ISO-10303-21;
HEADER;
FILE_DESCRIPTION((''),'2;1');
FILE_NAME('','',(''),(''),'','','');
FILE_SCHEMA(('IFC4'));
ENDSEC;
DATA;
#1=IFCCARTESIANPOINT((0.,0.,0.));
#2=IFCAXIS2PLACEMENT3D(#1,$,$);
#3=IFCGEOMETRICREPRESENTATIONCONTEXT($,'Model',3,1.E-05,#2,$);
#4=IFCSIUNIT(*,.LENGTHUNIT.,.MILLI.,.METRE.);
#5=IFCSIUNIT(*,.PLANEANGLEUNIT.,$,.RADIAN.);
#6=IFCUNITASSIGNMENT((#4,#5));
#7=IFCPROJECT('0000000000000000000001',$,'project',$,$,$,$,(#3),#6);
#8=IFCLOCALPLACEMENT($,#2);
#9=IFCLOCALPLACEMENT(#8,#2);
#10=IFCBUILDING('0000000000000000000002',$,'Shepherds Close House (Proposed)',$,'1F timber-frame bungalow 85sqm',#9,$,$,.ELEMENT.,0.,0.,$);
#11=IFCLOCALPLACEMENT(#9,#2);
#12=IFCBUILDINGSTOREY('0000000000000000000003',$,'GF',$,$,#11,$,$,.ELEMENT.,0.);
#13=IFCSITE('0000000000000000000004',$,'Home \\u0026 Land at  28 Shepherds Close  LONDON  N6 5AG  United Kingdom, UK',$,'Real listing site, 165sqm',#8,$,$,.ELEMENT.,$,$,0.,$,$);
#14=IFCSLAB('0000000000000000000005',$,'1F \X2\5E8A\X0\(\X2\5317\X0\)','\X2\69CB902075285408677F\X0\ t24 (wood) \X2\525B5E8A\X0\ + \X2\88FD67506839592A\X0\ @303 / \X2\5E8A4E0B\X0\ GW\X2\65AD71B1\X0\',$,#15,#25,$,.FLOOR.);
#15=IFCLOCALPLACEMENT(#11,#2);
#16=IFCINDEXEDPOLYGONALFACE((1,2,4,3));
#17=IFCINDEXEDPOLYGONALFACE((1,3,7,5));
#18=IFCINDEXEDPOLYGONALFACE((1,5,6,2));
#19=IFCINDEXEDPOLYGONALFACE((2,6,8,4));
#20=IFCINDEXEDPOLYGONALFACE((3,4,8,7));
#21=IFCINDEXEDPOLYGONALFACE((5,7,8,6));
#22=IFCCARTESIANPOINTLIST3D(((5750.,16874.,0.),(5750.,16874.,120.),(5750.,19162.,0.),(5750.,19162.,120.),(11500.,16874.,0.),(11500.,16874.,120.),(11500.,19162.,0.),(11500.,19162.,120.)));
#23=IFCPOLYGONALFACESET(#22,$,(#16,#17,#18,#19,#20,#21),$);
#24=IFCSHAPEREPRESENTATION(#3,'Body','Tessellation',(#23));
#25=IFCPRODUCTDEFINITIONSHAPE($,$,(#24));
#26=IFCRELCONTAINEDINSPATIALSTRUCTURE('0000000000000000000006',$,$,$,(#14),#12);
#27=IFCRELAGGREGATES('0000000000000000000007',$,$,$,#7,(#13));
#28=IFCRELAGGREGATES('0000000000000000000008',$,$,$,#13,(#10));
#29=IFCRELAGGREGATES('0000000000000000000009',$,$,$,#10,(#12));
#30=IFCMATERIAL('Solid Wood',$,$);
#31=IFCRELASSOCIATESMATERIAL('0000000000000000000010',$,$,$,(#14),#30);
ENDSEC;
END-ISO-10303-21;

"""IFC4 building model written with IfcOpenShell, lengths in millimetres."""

from ifc_helpers import new_model, si_unit, frame, frame_2d, origin, place, context, project, spatial, rectangle, extrude, material, element, save


model = new_model("IFC4")

# Units and contexts
model_context = context("Model", 3, precision=1e-05, world=origin())
ifc_project = project(units=[si_unit("LENGTHUNIT", "METRE", prefix="MILLI"), si_unit("PLANEANGLEUNIT", "RADIAN")], contexts=[model_context])

# Site, building, storey
site_placement = place(None, origin())
site = spatial("IfcSite", under=ifc_project, at=site_placement, Name="Home \\u0026 Land at  28 Shepherds Close  LONDON  N6 5AG  United Kingdom, UK", ObjectType="Real listing site, 165sqm", CompositionType="ELEMENT", RefElevation=0.0)
building_placement = place(site_placement, origin())
building = spatial("IfcBuilding", under=site, at=building_placement, Name="Shepherds Close House (Proposed)", ObjectType="1F timber-frame bungalow 85sqm", CompositionType="ELEMENT", ElevationOfRefHeight=0.0, ElevationOfTerrain=0.0)
storey_placement = place(building_placement, origin())
storey = spatial("IfcBuildingStorey", under=building, at=storey_placement, Name="GF", CompositionType="ELEMENT", Elevation=0.0)

# Slab
ifc_material_1 = material(Name="Solid Wood")
slab_1_placement = place(storey_placement, frame((2875.0, 8437.0, 0.0)))
element("IfcSlab", 1, at=slab_1_placement, inside=storey, material=ifc_material_1, Name="1F 床(北)", Description="構造用合板 t24 (wood) 剛床 + 製材根太 @303 / 床下 GW断熱", PredefinedType="FLOOR", context=model_context, shape_type="SweptSolid", body=[
    extrude(rectangle(XDim=5750.0, YDim=2288.0, at=frame_2d((2875.0, 1144.0))), frame((2875.0, 8437.0, 0.0)), (0.0, 0.0, 1.0), 120.0),
])

save(model, "model.ifc")
